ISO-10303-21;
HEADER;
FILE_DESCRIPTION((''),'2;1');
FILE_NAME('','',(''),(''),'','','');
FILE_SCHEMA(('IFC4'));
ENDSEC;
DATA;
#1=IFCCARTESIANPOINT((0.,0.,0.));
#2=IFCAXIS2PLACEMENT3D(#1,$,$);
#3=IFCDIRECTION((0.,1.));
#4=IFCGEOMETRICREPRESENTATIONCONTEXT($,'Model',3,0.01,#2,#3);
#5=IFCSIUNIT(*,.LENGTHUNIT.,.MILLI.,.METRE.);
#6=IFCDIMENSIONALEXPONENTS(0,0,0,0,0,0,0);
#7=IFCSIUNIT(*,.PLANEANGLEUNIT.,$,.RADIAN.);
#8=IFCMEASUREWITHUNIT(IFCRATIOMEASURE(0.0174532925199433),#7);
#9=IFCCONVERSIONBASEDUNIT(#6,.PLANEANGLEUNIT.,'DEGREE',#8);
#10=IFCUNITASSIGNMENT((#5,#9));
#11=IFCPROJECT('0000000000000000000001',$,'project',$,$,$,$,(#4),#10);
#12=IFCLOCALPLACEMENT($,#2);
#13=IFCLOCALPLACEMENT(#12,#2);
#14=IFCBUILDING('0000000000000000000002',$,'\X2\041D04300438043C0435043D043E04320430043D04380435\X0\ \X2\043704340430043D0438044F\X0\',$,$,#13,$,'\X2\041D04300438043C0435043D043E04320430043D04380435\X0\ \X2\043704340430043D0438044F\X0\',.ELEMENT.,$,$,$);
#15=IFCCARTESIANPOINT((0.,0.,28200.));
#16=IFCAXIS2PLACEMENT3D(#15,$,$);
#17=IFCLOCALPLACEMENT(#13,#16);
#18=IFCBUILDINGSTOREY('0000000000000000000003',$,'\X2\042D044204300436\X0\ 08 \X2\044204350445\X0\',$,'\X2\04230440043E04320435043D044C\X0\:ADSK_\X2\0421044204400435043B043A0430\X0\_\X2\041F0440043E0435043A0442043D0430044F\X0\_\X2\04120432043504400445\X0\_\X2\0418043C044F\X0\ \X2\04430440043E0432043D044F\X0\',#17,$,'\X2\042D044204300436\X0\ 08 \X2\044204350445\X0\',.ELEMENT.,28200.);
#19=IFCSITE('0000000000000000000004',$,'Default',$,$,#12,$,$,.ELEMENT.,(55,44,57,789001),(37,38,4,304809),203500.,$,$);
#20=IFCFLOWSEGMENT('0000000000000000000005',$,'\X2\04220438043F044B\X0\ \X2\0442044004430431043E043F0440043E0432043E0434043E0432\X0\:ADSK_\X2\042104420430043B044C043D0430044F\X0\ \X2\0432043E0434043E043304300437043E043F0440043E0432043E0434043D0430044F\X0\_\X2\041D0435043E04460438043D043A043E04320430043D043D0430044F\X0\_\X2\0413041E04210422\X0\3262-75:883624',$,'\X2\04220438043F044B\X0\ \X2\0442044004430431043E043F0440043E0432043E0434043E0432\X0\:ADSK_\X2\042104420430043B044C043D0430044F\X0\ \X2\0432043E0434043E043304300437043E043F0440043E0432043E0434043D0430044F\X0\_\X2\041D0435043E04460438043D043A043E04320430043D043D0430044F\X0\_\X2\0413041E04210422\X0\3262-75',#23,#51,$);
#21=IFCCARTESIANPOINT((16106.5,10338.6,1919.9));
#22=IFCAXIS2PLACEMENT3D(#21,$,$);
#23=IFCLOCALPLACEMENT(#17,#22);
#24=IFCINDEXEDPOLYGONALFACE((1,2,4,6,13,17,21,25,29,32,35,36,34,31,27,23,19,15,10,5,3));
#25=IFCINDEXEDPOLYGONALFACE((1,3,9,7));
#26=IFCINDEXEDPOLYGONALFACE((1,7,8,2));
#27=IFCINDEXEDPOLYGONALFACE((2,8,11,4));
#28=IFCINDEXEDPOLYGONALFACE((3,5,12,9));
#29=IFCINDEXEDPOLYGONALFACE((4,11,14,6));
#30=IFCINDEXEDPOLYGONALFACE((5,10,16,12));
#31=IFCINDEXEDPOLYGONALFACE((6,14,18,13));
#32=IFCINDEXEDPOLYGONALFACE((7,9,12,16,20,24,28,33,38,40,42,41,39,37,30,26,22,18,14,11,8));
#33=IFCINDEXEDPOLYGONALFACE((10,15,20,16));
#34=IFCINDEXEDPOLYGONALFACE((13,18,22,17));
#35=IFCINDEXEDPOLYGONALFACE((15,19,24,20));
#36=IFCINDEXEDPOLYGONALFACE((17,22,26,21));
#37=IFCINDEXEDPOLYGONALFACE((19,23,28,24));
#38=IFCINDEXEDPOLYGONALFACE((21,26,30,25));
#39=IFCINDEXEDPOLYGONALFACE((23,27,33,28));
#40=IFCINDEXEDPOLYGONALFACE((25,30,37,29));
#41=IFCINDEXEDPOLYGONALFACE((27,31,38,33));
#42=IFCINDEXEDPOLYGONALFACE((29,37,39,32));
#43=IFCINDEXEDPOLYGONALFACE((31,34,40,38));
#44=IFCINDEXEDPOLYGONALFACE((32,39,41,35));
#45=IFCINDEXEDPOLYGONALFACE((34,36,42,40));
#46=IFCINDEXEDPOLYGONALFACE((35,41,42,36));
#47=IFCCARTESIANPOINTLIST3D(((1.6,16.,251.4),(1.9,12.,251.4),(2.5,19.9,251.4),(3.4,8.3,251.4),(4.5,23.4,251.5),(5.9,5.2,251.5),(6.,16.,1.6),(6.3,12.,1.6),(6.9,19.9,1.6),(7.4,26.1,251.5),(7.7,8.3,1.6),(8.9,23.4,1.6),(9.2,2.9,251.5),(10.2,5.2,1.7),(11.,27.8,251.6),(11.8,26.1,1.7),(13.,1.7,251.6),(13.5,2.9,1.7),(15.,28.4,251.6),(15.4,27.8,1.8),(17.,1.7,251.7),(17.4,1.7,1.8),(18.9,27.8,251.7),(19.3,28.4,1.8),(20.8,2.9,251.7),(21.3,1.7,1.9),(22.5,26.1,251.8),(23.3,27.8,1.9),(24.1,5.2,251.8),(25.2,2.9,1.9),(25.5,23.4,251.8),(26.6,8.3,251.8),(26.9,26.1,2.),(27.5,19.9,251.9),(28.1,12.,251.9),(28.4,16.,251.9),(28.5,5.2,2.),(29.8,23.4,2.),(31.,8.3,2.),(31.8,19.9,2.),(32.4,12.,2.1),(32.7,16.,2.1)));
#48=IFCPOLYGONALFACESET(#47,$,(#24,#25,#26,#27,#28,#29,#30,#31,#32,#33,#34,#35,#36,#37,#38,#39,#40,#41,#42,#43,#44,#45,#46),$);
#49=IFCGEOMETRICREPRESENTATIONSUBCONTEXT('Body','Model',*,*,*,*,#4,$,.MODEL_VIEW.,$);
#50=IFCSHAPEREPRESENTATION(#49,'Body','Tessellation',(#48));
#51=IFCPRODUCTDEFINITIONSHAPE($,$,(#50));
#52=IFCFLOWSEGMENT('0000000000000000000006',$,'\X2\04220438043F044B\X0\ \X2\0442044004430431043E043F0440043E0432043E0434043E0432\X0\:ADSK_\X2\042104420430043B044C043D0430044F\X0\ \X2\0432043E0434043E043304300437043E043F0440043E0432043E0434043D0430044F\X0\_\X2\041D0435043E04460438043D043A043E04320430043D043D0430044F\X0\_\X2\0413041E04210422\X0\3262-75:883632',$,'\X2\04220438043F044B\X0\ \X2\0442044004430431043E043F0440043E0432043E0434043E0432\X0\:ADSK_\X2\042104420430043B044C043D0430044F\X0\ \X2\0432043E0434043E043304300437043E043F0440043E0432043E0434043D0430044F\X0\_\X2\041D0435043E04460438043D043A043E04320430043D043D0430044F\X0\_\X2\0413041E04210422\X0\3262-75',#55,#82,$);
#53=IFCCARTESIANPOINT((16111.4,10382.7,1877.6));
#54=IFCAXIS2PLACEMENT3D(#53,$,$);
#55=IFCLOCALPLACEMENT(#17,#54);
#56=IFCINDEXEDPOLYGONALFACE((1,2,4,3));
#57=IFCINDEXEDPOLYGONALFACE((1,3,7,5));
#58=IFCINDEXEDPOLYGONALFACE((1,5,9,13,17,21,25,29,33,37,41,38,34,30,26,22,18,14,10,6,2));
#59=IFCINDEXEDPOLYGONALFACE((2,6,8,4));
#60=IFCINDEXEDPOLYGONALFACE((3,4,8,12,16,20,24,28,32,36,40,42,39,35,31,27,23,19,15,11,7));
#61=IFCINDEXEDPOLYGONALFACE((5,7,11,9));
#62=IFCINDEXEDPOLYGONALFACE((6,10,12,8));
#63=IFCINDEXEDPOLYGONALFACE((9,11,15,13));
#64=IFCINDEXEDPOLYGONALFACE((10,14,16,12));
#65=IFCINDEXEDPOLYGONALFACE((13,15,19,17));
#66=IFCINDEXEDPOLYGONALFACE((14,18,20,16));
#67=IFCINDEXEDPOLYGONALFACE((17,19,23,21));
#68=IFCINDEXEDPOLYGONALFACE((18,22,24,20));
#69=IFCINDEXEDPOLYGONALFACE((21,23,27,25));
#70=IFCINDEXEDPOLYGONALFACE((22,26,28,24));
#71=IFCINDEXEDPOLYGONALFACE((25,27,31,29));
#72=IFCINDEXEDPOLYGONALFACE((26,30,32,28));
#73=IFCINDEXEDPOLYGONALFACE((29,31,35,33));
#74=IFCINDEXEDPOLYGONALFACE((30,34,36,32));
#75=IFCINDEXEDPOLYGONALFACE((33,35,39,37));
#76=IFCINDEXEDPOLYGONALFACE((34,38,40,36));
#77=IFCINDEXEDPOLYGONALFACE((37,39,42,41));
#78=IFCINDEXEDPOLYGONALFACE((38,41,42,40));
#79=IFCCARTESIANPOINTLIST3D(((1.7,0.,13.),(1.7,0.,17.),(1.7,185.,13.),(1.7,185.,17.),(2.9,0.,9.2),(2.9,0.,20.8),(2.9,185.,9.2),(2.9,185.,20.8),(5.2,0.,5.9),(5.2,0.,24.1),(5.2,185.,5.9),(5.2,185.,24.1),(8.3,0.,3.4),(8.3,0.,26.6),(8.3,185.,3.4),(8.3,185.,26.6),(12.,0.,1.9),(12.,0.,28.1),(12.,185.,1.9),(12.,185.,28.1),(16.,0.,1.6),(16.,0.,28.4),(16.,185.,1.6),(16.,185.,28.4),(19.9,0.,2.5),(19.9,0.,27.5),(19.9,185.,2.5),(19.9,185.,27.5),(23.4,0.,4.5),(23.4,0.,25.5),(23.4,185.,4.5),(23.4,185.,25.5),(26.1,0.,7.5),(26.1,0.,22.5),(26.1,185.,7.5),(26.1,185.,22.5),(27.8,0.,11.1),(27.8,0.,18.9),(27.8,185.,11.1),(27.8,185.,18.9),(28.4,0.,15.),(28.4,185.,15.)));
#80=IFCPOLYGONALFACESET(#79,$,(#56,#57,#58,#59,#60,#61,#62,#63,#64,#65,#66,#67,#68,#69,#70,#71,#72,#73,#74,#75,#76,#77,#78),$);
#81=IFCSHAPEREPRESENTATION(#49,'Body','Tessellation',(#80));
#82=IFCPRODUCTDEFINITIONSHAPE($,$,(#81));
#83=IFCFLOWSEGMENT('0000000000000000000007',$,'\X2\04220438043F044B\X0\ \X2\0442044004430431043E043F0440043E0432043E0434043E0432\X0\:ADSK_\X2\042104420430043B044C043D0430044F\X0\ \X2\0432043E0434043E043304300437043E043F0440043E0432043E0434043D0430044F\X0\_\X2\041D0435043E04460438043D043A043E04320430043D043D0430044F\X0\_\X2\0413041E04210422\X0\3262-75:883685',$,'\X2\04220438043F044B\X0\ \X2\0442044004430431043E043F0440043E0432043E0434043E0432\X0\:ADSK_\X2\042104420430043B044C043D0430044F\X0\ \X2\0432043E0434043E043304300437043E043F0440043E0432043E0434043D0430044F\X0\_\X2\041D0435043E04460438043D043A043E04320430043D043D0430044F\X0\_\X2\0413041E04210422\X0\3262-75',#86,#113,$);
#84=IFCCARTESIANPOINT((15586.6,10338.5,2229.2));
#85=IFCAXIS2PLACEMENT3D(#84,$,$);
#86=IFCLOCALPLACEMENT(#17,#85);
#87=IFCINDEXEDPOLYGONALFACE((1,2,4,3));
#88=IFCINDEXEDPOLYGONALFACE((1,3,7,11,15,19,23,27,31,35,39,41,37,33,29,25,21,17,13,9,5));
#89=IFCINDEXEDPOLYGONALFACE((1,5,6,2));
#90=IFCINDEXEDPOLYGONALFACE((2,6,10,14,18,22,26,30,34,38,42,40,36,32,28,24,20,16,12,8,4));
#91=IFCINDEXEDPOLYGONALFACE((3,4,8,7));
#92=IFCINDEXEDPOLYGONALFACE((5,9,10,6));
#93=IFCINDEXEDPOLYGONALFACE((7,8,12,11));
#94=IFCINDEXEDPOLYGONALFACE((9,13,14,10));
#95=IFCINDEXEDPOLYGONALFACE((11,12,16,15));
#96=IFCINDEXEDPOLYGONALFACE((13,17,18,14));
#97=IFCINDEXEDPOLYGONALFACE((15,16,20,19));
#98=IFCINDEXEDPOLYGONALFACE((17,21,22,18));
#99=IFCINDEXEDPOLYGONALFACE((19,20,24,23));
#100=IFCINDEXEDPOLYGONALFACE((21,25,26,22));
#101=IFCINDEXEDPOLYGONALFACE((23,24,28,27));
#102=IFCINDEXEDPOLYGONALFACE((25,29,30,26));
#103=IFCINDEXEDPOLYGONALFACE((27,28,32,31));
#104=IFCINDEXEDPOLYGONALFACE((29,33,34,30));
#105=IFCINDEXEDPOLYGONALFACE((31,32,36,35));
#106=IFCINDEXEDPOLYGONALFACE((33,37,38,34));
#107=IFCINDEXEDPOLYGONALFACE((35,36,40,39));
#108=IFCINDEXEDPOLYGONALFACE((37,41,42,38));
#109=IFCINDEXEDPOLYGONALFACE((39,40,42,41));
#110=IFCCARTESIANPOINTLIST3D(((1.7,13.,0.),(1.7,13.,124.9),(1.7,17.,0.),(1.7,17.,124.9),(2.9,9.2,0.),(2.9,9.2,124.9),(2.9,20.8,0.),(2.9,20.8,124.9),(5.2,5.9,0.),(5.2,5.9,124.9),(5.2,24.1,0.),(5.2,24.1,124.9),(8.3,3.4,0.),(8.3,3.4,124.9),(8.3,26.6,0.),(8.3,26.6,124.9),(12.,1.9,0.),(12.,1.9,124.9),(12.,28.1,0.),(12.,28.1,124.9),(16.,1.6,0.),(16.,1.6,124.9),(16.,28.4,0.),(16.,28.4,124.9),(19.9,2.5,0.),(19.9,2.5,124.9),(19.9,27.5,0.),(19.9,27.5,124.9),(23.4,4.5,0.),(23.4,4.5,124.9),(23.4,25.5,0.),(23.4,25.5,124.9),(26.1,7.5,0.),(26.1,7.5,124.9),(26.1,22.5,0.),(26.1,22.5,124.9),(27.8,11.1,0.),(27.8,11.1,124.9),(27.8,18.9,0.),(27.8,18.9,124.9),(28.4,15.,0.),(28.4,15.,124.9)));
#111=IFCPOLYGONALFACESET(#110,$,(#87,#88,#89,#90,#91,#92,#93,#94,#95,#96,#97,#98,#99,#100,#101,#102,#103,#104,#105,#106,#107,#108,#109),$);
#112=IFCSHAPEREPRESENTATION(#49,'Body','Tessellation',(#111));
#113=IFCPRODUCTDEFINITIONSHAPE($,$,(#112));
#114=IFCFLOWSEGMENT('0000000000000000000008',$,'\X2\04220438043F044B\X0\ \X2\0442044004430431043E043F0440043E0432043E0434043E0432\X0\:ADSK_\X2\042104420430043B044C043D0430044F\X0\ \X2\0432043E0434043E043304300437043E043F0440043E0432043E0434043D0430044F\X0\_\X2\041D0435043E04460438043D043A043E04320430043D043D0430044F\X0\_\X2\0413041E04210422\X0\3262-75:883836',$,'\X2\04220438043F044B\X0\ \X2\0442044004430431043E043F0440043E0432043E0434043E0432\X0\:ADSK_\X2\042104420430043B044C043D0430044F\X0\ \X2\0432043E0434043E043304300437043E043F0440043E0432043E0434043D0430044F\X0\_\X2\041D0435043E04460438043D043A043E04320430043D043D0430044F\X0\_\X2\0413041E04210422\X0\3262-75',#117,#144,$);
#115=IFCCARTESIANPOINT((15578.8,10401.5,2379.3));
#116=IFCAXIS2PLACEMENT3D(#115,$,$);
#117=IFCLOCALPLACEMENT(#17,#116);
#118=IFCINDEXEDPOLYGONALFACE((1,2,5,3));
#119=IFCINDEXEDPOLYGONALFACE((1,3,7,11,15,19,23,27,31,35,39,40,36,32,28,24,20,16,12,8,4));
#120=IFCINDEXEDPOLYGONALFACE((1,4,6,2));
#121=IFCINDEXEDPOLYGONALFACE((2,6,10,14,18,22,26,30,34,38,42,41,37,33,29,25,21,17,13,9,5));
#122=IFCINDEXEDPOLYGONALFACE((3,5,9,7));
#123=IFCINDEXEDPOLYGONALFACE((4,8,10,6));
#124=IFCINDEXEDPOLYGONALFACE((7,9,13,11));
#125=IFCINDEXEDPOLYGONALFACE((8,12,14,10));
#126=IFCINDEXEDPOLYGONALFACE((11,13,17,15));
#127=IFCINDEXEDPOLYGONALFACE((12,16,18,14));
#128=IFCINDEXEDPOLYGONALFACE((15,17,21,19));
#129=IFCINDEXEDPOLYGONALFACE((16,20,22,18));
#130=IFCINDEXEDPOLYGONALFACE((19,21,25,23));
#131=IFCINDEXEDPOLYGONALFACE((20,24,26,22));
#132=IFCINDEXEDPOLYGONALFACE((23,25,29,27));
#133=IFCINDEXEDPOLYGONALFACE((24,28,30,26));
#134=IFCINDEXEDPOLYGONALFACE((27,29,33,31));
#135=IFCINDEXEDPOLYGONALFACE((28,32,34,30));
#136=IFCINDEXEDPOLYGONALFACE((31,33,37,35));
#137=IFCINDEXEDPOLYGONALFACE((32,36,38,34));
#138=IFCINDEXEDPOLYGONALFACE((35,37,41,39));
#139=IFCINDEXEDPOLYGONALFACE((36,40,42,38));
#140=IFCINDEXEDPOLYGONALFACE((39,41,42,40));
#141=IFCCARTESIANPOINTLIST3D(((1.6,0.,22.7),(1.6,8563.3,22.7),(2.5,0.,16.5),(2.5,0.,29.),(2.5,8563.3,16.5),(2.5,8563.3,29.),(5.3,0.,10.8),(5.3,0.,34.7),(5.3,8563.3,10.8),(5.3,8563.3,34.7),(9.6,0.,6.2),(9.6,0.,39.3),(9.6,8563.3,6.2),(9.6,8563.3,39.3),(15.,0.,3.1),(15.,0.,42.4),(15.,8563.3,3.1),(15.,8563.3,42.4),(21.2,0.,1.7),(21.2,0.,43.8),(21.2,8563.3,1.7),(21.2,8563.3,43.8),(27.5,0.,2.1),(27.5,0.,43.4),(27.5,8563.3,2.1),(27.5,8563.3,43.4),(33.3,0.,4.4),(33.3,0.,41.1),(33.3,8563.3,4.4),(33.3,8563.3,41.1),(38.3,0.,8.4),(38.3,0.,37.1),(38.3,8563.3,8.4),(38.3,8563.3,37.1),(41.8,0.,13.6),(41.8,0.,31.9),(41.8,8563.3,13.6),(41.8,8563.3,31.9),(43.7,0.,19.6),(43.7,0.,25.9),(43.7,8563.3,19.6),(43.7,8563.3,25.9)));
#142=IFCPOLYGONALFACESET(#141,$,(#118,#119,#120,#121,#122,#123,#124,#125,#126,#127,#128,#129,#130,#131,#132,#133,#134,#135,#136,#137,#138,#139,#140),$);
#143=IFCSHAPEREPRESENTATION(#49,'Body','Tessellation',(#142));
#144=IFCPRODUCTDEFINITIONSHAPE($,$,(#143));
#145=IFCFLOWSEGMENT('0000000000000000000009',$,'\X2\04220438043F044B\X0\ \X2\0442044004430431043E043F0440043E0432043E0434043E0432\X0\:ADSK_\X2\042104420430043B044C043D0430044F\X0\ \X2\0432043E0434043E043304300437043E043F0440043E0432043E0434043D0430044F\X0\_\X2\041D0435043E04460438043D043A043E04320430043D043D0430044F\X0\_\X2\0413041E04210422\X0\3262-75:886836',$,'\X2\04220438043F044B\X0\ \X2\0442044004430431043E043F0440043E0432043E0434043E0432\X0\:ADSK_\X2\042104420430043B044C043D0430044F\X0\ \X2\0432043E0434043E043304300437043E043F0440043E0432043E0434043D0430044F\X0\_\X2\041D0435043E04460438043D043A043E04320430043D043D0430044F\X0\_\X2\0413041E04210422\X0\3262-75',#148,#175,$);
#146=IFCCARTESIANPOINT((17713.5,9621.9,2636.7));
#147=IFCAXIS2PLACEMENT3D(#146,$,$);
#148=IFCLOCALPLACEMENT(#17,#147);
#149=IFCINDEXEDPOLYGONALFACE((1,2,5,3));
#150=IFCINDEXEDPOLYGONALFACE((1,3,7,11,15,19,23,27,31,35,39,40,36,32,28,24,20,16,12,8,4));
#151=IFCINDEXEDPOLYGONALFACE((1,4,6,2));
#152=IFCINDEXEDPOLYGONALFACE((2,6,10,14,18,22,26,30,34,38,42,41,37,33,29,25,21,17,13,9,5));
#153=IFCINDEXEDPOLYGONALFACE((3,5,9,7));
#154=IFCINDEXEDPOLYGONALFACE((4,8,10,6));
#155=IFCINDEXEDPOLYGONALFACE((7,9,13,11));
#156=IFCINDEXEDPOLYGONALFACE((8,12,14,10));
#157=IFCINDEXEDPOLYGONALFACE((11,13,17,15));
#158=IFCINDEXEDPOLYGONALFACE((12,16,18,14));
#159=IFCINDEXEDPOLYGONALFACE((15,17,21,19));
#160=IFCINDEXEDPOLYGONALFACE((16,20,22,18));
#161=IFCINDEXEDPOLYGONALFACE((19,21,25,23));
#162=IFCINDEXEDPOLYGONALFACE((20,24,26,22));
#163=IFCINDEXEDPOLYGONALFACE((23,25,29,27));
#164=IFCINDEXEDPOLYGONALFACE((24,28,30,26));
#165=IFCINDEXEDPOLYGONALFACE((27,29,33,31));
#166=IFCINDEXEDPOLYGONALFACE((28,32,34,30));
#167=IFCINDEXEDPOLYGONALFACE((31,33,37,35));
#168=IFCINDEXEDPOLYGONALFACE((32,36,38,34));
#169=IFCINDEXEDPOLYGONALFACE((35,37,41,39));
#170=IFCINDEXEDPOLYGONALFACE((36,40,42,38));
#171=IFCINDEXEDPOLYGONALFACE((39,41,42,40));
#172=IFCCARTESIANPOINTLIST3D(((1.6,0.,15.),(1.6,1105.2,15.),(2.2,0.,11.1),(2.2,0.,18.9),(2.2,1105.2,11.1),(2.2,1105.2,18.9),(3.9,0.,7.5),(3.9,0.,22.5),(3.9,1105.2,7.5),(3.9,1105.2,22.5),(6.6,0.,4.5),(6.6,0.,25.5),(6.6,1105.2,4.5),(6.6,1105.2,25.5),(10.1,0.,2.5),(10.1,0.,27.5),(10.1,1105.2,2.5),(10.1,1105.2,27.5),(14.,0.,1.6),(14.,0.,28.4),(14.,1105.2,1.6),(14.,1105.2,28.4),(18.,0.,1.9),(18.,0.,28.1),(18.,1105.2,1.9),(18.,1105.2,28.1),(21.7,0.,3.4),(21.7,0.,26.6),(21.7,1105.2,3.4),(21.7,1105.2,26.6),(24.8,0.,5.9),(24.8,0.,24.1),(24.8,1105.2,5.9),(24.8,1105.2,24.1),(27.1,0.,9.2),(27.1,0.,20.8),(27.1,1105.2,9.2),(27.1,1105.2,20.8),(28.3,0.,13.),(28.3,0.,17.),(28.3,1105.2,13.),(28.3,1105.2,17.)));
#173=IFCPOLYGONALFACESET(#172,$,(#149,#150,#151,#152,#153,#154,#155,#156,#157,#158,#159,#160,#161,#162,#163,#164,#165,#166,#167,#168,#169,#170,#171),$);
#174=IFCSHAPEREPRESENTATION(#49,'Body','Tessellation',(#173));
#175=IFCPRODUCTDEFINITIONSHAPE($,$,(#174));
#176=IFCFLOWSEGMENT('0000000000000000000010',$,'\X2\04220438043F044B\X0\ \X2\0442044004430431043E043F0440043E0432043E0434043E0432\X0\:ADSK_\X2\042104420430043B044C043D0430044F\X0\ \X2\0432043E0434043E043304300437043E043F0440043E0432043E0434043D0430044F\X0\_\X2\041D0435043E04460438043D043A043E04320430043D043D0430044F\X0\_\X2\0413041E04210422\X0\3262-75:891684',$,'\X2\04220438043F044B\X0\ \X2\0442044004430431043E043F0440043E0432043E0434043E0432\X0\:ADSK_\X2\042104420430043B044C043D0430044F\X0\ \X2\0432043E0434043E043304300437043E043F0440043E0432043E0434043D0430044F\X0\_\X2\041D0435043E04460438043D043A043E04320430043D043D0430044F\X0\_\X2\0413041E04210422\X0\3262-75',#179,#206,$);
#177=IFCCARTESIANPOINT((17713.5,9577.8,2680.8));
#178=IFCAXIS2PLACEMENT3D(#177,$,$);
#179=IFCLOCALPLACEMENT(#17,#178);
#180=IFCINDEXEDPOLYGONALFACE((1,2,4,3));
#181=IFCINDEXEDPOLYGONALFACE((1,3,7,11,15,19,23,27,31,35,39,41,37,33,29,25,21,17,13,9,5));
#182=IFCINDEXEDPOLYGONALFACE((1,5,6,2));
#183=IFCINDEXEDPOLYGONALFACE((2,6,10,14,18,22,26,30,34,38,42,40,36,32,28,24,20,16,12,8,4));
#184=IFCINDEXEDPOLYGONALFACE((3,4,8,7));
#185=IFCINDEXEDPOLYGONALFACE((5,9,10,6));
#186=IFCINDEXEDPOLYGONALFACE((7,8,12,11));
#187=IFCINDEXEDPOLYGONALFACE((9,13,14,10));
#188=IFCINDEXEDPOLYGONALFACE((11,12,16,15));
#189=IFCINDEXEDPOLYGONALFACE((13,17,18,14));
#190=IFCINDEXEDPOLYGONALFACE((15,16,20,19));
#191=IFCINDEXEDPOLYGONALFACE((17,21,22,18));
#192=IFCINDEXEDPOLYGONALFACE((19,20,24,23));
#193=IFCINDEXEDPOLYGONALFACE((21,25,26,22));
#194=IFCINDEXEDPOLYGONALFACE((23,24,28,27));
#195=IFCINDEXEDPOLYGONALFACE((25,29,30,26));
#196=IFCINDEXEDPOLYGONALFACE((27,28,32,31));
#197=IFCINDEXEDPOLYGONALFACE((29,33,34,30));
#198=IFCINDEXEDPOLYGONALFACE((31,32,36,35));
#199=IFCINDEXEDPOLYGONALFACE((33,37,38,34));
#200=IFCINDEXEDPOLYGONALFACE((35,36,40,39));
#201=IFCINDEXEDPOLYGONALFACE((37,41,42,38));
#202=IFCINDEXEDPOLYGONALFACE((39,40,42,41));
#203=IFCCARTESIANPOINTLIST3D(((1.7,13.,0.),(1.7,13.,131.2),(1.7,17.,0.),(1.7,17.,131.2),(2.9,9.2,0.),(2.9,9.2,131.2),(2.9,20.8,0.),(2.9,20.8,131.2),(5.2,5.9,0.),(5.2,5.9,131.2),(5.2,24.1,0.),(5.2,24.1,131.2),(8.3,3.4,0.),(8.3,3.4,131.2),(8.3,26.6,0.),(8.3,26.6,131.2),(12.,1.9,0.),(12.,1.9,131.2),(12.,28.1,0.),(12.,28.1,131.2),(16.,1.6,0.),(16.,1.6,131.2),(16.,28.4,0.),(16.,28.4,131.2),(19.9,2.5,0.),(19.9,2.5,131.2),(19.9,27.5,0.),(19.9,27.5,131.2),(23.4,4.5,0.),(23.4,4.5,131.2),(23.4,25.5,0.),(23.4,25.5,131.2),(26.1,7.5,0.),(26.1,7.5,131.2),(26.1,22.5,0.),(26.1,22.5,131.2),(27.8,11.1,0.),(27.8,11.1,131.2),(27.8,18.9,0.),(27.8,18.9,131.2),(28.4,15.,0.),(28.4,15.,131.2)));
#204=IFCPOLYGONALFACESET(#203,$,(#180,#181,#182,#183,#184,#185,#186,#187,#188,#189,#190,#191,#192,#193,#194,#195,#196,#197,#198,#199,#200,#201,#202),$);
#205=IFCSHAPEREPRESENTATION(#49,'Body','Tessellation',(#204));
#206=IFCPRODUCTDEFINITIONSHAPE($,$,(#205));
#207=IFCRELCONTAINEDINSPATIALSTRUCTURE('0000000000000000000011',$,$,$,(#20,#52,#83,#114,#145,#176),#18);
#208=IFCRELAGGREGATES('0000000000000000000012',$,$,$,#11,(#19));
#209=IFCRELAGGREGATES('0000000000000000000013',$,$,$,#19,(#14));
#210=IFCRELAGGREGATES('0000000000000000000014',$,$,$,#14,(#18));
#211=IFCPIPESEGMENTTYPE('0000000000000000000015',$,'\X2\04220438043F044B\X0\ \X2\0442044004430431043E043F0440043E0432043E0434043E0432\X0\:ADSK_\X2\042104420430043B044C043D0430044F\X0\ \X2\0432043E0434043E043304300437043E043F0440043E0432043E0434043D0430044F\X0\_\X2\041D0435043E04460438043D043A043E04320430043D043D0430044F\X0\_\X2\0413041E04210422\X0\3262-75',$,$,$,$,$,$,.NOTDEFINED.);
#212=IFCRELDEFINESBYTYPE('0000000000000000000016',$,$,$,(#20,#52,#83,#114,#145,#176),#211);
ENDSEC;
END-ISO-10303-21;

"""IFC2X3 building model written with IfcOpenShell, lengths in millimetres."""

from ifc_helpers import new_model, entity, si_unit, converted_unit, direction, frame, origin, origin_2d_with_axis, place, context, subcontext, project, spatial, circle, extrude, type_object, element, save


model = new_model("IFC2X3")

# Units and contexts
model_context = context("Model", 3, precision=0.01, world=origin(), true_north=direction((0.0, 1.0)))
body_context = subcontext(model_context, "Body", "Model", "MODEL_VIEW")
ifc_project = project(units=[si_unit("LENGTHUNIT", "METRE", prefix="MILLI"), converted_unit("PLANEANGLEUNIT", "DEGREE", entity("IfcRatioMeasure", 0.0174532925199433), si_unit("PLANEANGLEUNIT", "RADIAN"), dimensions=[0, 0, 0, 0, 0, 0, 0])], contexts=[model_context])

# Site, building, storey
site_placement = place(None, origin())
site = spatial("IfcSite", under=ifc_project, at=site_placement, Name="Default", CompositionType="ELEMENT", RefLatitude=(55, 44, 57, 789001), RefLongitude=(37, 38, 4, 304809), RefElevation=203500.0)
building_placement = place(site_placement, origin())
building = spatial("IfcBuilding", under=site, at=building_placement, Name="Наименование здания", LongName="Наименование здания", CompositionType="ELEMENT")
storey_placement = place(building_placement, frame((0.0, 0.0, 28200.0)))
storey = spatial("IfcBuildingStorey", under=building, at=storey_placement, Name="Этаж 08 тех", ObjectType="Уровень:ADSK_Стрелка_Проектная_Вверх_Имя уровня", LongName="Этаж 08 тех", CompositionType="ELEMENT", Elevation=28200.0)

# Flow segments
pipe_segment_type = type_object("IfcPipeSegmentType", Name="Типы трубопроводов:ADSK_Стальная водогазопроводная_Неоцинкованная_ГОСТ3262-75", PredefinedType="NOTDEFINED")
flow_segment_1_placement = place(storey_placement, frame((16106.5, 10338.6, 1919.9)))
element("IfcFlowSegment", 1, at=flow_segment_1_placement, inside=storey, type_object=pipe_segment_type, Name="Типы трубопроводов:ADSK_Стальная водогазопроводная_Неоцинкованная_ГОСТ3262-75:883624", ObjectType="Типы трубопроводов:ADSK_Стальная водогазопроводная_Неоцинкованная_ГОСТ3262-75", context=body_context, shape_type="SweptSolid", body=[
    extrude(circle(Radius=13.4, at=origin_2d_with_axis()), frame((19.4, 15.0, 1.8), z_axis=(-0.017452, 0.0, 0.999848), x_axis=(0.0, 1.0, 0.0)), (0.0, 0.0, 1.0), 249.8),
])
flow_segment_2_placement = place(storey_placement, frame((16111.4, 10382.7, 1877.6)))
element("IfcFlowSegment", 2, at=flow_segment_2_placement, inside=storey, type_object=pipe_segment_type, Name="Типы трубопроводов:ADSK_Стальная водогазопроводная_Неоцинкованная_ГОСТ3262-75:883632", ObjectType="Типы трубопроводов:ADSK_Стальная водогазопроводная_Неоцинкованная_ГОСТ3262-75", context=body_context, shape_type="SweptSolid", body=[
    extrude(circle(Radius=13.4, at=origin_2d_with_axis()), frame((15.0, 0.0, 15.0), z_axis=(0.0, 1.0, 0.0), x_axis=(1.0, 0.0, 0.0)), (0.0, 0.0, 1.0), 185.0),
])
flow_segment_3_placement = place(storey_placement, frame((15586.6, 10338.5, 2229.2)))
element("IfcFlowSegment", 3, at=flow_segment_3_placement, inside=storey, type_object=pipe_segment_type, Name="Типы трубопроводов:ADSK_Стальная водогазопроводная_Неоцинкованная_ГОСТ3262-75:883685", ObjectType="Типы трубопроводов:ADSK_Стальная водогазопроводная_Неоцинкованная_ГОСТ3262-75", context=body_context, shape_type="SweptSolid", body=[
    extrude(circle(Radius=13.4, at=origin_2d_with_axis()), frame((15.0, 15.0, 0.0)), (0.0, 0.0, 1.0), 124.9),
])
flow_segment_4_placement = place(storey_placement, frame((15578.8, 10401.5, 2379.3)))
element("IfcFlowSegment", 4, at=flow_segment_4_placement, inside=storey, type_object=pipe_segment_type, Name="Типы трубопроводов:ADSK_Стальная водогазопроводная_Неоцинкованная_ГОСТ3262-75:883836", ObjectType="Типы трубопроводов:ADSK_Стальная водогазопроводная_Неоцинкованная_ГОСТ3262-75", context=body_context, shape_type="SweptSolid", body=[
    extrude(circle(Radius=21.1, at=origin_2d_with_axis()), frame((22.8, 0.0, 22.8), z_axis=(0.0, 1.0, 0.0), x_axis=(-1.0, 0.0, 0.0)), (0.0, 0.0, 1.0), 8563.3),
])
flow_segment_5_placement = place(storey_placement, frame((17713.5, 9621.9, 2636.7)))
element("IfcFlowSegment", 5, at=flow_segment_5_placement, inside=storey, type_object=pipe_segment_type, Name="Типы трубопроводов:ADSK_Стальная водогазопроводная_Неоцинкованная_ГОСТ3262-75:886836", ObjectType="Типы трубопроводов:ADSK_Стальная водогазопроводная_Неоцинкованная_ГОСТ3262-75", context=body_context, shape_type="SweptSolid", body=[
    extrude(circle(Radius=13.4, at=origin_2d_with_axis()), frame((15.0, 0.0, 15.0), z_axis=(0.0, 1.0, 0.0), x_axis=(-1.0, 0.0, 0.0)), (0.0, 0.0, 1.0), 1105.2),
])
flow_segment_6_placement = place(storey_placement, frame((17713.5, 9577.8, 2680.8)))
element("IfcFlowSegment", 6, at=flow_segment_6_placement, inside=storey, type_object=pipe_segment_type, Name="Типы трубопроводов:ADSK_Стальная водогазопроводная_Неоцинкованная_ГОСТ3262-75:891684", ObjectType="Типы трубопроводов:ADSK_Стальная водогазопроводная_Неоцинкованная_ГОСТ3262-75", context=body_context, shape_type="SweptSolid", body=[
    extrude(circle(Radius=13.4, at=origin_2d_with_axis()), frame((15.0, 15.0, 0.0)), (0.0, 0.0, 1.0), 131.2),
])

save(model, "model.ifc")
